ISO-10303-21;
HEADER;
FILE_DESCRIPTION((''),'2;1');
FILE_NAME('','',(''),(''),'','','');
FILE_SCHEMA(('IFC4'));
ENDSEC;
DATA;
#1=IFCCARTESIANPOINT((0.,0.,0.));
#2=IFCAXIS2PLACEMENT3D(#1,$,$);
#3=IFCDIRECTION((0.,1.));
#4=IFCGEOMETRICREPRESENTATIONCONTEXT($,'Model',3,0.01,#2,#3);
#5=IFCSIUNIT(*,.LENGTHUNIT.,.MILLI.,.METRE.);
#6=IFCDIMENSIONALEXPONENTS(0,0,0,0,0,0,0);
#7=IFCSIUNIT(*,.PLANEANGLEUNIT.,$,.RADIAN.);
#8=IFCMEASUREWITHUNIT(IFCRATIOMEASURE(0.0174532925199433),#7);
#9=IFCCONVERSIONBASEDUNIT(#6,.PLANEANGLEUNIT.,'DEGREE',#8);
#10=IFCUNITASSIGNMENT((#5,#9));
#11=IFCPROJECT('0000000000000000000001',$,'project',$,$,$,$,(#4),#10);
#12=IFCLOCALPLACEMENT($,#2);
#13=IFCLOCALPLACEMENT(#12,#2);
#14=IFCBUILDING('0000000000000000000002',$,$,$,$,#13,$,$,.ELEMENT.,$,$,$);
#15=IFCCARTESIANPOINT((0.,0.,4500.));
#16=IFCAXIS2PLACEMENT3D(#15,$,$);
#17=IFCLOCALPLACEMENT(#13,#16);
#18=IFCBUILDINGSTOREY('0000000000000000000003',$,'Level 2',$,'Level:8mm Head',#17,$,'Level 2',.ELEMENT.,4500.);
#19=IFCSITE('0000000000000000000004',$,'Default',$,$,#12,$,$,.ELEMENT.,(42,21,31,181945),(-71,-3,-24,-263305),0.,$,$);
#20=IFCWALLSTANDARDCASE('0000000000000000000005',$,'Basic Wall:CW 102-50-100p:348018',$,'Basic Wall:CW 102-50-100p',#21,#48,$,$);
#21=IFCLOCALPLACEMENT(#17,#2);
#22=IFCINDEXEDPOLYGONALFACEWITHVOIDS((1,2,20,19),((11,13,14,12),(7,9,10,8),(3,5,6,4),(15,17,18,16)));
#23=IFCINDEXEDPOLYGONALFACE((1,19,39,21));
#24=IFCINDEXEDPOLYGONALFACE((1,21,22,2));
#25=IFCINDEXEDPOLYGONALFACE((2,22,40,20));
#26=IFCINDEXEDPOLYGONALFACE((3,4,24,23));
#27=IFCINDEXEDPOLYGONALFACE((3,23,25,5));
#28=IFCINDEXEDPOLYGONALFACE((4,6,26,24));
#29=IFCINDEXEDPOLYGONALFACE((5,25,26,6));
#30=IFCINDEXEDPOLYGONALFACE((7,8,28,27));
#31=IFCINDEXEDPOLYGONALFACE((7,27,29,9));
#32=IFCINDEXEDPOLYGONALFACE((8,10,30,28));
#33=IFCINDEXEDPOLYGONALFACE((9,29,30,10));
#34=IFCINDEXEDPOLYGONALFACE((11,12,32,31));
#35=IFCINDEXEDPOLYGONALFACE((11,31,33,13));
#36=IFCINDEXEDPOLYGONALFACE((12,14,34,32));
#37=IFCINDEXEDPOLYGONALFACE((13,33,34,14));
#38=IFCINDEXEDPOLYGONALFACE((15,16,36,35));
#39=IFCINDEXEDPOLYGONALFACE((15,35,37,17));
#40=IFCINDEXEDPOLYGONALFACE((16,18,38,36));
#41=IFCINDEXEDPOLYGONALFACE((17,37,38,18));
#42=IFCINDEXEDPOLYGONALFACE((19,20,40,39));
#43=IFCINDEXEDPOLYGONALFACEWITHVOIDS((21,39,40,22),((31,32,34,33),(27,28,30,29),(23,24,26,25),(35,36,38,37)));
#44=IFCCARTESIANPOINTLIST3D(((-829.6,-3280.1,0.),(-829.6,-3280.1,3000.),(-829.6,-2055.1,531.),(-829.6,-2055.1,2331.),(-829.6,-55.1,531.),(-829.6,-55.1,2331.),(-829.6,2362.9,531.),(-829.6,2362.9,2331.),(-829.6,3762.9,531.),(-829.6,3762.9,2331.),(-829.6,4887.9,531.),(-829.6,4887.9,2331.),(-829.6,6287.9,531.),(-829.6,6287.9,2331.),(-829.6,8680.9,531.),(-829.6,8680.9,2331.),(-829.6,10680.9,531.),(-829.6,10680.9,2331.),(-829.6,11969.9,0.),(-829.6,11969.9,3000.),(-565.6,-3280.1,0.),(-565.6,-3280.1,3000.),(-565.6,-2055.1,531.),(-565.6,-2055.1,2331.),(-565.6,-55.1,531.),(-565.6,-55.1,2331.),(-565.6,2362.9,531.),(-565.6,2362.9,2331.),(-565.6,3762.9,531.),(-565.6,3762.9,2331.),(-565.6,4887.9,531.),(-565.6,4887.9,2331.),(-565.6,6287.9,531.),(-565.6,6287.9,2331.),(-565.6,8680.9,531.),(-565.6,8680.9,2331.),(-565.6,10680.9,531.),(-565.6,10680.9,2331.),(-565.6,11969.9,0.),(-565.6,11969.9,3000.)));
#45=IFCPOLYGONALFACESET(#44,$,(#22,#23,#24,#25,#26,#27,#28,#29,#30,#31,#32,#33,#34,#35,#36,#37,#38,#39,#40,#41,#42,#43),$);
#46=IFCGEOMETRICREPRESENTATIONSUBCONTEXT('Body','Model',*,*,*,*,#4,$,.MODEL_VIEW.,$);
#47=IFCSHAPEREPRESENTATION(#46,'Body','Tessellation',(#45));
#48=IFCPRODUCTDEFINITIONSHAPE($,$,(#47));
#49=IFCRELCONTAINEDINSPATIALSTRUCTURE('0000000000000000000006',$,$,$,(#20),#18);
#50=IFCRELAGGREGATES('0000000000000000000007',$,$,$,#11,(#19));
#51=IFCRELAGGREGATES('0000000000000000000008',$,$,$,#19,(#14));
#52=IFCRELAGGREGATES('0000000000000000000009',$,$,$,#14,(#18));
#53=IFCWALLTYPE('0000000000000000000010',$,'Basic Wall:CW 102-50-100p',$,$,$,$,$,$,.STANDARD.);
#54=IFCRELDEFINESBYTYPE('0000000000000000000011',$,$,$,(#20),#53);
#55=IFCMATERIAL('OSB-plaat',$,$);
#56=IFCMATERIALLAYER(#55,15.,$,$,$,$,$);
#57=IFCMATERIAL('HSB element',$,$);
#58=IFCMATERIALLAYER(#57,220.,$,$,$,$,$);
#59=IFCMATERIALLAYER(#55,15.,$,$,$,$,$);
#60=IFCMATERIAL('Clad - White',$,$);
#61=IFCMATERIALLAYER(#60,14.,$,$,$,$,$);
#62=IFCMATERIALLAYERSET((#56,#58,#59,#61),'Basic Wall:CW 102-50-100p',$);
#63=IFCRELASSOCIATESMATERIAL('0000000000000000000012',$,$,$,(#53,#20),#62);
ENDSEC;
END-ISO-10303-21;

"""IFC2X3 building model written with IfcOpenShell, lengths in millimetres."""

from ifc_helpers import new_model, entity, si_unit, converted_unit, direction, frame, frame_2d, origin, place, context, subcontext, project, spatial, rectangle, extrude, material, layer, layer_set, layer_usage, type_object, element, save


model = new_model("IFC2X3")

# Units and contexts
model_context = context("Model", 3, precision=0.01, world=origin(), true_north=direction((0.0, 1.0)))
body_context = subcontext(model_context, "Body", "Model", "MODEL_VIEW")
ifc_project = project(units=[si_unit("LENGTHUNIT", "METRE", prefix="MILLI"), converted_unit("PLANEANGLEUNIT", "DEGREE", entity("IfcRatioMeasure", 0.0174532925199433), si_unit("PLANEANGLEUNIT", "RADIAN"), dimensions=[0, 0, 0, 0, 0, 0, 0])], contexts=[model_context])

# Site, building, storey
site_placement = place(None, frame((0.0, 0.0, 0.0)))
site = spatial("IfcSite", under=ifc_project, at=site_placement, Name="Default", CompositionType="ELEMENT", RefLatitude=(42, 21, 31, 181945), RefLongitude=(-71, -3, -24, -263305), RefElevation=0.0)
building_placement = place(site_placement, origin())
building = spatial("IfcBuilding", under=site, at=building_placement, CompositionType="ELEMENT")
storey_placement = place(building_placement, frame((0.0, 0.0, 4500.0)))
storey = spatial("IfcBuildingStorey", under=building, at=storey_placement, Name="Level 2", ObjectType="Level:8mm Head", LongName="Level 2", CompositionType="ELEMENT", Elevation=4500.0)

# Shared definitions
ifc_material_1 = material(Name="OSB-plaat")

# Wall, openings
ifc_layer_1 = layer(ifc_material_1, 15.0)
ifc_material_2 = material(Name="HSB element")
ifc_layer_2 = layer(ifc_material_2, 220.0)
ifc_layer_3 = layer(ifc_material_1, 15.0)
ifc_material_3 = material(Name="Clad - White")
ifc_layer_4 = layer(ifc_material_3, 14.0)
ifc_layer_set = layer_set([ifc_layer_1, ifc_layer_2, ifc_layer_3, ifc_layer_4], Name="Basic Wall:CW 102-50-100p")
ifc_layer_usage = layer_usage(ifc_layer_set, "AXIS2", "POSITIVE", -132.0)
wall_type = type_object("IfcWallType", Name="Basic Wall:CW 102-50-100p", PredefinedType="STANDARD", material=ifc_layer_set)
wall_placement = place(storey_placement, frame((-697.6, -3280.1, 0.0), z_axis=(0.0, 0.0, 1.0), x_axis=(0.0, 1.0, 0.0)))
wall = element("IfcWallStandardCase", 1, at=wall_placement, inside=storey, type_object=wall_type, material=ifc_layer_usage, Name="Basic Wall:CW 102-50-100p:348018", ObjectType="Basic Wall:CW 102-50-100p", context=body_context, shape_type="SweptSolid", body=[
    extrude(rectangle(XDim=15250.0, YDim=264.0, at=frame_2d((7625.0, 0.0), x_axis=(-1.0, 0.0))), origin(), (0.0, 0.0, 1.0), 3000.0),
])
opening_1_placement = place(wall_placement, frame((9568.0, 132.0, 531.0)))
element("IfcOpeningElement", 2, at=opening_1_placement, cuts=wall, ObjectType="Opening", context=body_context, shape_type="SweptSolid", body=[
    extrude(rectangle(XDim=1800.0, YDim=1400.0, at=frame_2d((900.0, 700.0), x_axis=(-1.0, 0.0))), frame((0.0, 0.0, 0.0), z_axis=(0.0, -1.0, 0.0), x_axis=(0.0, 0.0, 1.0)), (0.0, 0.0, 1.0), 264.0),
])
opening_2_placement = place(wall_placement, frame((7043.0, 132.0, 531.0)))
element("IfcOpeningElement", 3, at=opening_2_placement, cuts=wall, ObjectType="Opening", context=body_context, shape_type="SweptSolid", body=[
    extrude(rectangle(XDim=1800.0, YDim=1400.0, at=frame_2d((900.0, 700.0), x_axis=(-1.0, 0.0))), frame((0.0, 0.0, 0.0), z_axis=(0.0, -1.0, 0.0), x_axis=(0.0, 0.0, 1.0)), (0.0, 0.0, 1.0), 264.0),
])
opening_3_placement = place(wall_placement, frame((3225.0, 132.0, 531.0)))
element("IfcOpeningElement", 4, at=opening_3_placement, cuts=wall, ObjectType="Opening", context=body_context, shape_type="SweptSolid", body=[
    extrude(rectangle(XDim=1800.0, YDim=2000.0, at=frame_2d((900.0, 1000.0), x_axis=(-1.0, 0.0))), frame((0.0, 0.0, 0.0), z_axis=(0.0, -1.0, 0.0), x_axis=(0.0, 0.0, 1.0)), (0.0, 0.0, 1.0), 264.0),
])
opening_4_placement = place(wall_placement, frame((13961.0, 132.0, 531.0)))
element("IfcOpeningElement", 5, at=opening_4_placement, cuts=wall, ObjectType="Opening", context=body_context, shape_type="SweptSolid", body=[
    extrude(rectangle(XDim=1800.0, YDim=2000.0, at=frame_2d((900.0, 1000.0), x_axis=(-1.0, 0.0))), frame((0.0, 0.0, 0.0), z_axis=(0.0, -1.0, 0.0), x_axis=(0.0, 0.0, 1.0)), (0.0, 0.0, 1.0), 264.0),
])

save(model, "model.ifc")
